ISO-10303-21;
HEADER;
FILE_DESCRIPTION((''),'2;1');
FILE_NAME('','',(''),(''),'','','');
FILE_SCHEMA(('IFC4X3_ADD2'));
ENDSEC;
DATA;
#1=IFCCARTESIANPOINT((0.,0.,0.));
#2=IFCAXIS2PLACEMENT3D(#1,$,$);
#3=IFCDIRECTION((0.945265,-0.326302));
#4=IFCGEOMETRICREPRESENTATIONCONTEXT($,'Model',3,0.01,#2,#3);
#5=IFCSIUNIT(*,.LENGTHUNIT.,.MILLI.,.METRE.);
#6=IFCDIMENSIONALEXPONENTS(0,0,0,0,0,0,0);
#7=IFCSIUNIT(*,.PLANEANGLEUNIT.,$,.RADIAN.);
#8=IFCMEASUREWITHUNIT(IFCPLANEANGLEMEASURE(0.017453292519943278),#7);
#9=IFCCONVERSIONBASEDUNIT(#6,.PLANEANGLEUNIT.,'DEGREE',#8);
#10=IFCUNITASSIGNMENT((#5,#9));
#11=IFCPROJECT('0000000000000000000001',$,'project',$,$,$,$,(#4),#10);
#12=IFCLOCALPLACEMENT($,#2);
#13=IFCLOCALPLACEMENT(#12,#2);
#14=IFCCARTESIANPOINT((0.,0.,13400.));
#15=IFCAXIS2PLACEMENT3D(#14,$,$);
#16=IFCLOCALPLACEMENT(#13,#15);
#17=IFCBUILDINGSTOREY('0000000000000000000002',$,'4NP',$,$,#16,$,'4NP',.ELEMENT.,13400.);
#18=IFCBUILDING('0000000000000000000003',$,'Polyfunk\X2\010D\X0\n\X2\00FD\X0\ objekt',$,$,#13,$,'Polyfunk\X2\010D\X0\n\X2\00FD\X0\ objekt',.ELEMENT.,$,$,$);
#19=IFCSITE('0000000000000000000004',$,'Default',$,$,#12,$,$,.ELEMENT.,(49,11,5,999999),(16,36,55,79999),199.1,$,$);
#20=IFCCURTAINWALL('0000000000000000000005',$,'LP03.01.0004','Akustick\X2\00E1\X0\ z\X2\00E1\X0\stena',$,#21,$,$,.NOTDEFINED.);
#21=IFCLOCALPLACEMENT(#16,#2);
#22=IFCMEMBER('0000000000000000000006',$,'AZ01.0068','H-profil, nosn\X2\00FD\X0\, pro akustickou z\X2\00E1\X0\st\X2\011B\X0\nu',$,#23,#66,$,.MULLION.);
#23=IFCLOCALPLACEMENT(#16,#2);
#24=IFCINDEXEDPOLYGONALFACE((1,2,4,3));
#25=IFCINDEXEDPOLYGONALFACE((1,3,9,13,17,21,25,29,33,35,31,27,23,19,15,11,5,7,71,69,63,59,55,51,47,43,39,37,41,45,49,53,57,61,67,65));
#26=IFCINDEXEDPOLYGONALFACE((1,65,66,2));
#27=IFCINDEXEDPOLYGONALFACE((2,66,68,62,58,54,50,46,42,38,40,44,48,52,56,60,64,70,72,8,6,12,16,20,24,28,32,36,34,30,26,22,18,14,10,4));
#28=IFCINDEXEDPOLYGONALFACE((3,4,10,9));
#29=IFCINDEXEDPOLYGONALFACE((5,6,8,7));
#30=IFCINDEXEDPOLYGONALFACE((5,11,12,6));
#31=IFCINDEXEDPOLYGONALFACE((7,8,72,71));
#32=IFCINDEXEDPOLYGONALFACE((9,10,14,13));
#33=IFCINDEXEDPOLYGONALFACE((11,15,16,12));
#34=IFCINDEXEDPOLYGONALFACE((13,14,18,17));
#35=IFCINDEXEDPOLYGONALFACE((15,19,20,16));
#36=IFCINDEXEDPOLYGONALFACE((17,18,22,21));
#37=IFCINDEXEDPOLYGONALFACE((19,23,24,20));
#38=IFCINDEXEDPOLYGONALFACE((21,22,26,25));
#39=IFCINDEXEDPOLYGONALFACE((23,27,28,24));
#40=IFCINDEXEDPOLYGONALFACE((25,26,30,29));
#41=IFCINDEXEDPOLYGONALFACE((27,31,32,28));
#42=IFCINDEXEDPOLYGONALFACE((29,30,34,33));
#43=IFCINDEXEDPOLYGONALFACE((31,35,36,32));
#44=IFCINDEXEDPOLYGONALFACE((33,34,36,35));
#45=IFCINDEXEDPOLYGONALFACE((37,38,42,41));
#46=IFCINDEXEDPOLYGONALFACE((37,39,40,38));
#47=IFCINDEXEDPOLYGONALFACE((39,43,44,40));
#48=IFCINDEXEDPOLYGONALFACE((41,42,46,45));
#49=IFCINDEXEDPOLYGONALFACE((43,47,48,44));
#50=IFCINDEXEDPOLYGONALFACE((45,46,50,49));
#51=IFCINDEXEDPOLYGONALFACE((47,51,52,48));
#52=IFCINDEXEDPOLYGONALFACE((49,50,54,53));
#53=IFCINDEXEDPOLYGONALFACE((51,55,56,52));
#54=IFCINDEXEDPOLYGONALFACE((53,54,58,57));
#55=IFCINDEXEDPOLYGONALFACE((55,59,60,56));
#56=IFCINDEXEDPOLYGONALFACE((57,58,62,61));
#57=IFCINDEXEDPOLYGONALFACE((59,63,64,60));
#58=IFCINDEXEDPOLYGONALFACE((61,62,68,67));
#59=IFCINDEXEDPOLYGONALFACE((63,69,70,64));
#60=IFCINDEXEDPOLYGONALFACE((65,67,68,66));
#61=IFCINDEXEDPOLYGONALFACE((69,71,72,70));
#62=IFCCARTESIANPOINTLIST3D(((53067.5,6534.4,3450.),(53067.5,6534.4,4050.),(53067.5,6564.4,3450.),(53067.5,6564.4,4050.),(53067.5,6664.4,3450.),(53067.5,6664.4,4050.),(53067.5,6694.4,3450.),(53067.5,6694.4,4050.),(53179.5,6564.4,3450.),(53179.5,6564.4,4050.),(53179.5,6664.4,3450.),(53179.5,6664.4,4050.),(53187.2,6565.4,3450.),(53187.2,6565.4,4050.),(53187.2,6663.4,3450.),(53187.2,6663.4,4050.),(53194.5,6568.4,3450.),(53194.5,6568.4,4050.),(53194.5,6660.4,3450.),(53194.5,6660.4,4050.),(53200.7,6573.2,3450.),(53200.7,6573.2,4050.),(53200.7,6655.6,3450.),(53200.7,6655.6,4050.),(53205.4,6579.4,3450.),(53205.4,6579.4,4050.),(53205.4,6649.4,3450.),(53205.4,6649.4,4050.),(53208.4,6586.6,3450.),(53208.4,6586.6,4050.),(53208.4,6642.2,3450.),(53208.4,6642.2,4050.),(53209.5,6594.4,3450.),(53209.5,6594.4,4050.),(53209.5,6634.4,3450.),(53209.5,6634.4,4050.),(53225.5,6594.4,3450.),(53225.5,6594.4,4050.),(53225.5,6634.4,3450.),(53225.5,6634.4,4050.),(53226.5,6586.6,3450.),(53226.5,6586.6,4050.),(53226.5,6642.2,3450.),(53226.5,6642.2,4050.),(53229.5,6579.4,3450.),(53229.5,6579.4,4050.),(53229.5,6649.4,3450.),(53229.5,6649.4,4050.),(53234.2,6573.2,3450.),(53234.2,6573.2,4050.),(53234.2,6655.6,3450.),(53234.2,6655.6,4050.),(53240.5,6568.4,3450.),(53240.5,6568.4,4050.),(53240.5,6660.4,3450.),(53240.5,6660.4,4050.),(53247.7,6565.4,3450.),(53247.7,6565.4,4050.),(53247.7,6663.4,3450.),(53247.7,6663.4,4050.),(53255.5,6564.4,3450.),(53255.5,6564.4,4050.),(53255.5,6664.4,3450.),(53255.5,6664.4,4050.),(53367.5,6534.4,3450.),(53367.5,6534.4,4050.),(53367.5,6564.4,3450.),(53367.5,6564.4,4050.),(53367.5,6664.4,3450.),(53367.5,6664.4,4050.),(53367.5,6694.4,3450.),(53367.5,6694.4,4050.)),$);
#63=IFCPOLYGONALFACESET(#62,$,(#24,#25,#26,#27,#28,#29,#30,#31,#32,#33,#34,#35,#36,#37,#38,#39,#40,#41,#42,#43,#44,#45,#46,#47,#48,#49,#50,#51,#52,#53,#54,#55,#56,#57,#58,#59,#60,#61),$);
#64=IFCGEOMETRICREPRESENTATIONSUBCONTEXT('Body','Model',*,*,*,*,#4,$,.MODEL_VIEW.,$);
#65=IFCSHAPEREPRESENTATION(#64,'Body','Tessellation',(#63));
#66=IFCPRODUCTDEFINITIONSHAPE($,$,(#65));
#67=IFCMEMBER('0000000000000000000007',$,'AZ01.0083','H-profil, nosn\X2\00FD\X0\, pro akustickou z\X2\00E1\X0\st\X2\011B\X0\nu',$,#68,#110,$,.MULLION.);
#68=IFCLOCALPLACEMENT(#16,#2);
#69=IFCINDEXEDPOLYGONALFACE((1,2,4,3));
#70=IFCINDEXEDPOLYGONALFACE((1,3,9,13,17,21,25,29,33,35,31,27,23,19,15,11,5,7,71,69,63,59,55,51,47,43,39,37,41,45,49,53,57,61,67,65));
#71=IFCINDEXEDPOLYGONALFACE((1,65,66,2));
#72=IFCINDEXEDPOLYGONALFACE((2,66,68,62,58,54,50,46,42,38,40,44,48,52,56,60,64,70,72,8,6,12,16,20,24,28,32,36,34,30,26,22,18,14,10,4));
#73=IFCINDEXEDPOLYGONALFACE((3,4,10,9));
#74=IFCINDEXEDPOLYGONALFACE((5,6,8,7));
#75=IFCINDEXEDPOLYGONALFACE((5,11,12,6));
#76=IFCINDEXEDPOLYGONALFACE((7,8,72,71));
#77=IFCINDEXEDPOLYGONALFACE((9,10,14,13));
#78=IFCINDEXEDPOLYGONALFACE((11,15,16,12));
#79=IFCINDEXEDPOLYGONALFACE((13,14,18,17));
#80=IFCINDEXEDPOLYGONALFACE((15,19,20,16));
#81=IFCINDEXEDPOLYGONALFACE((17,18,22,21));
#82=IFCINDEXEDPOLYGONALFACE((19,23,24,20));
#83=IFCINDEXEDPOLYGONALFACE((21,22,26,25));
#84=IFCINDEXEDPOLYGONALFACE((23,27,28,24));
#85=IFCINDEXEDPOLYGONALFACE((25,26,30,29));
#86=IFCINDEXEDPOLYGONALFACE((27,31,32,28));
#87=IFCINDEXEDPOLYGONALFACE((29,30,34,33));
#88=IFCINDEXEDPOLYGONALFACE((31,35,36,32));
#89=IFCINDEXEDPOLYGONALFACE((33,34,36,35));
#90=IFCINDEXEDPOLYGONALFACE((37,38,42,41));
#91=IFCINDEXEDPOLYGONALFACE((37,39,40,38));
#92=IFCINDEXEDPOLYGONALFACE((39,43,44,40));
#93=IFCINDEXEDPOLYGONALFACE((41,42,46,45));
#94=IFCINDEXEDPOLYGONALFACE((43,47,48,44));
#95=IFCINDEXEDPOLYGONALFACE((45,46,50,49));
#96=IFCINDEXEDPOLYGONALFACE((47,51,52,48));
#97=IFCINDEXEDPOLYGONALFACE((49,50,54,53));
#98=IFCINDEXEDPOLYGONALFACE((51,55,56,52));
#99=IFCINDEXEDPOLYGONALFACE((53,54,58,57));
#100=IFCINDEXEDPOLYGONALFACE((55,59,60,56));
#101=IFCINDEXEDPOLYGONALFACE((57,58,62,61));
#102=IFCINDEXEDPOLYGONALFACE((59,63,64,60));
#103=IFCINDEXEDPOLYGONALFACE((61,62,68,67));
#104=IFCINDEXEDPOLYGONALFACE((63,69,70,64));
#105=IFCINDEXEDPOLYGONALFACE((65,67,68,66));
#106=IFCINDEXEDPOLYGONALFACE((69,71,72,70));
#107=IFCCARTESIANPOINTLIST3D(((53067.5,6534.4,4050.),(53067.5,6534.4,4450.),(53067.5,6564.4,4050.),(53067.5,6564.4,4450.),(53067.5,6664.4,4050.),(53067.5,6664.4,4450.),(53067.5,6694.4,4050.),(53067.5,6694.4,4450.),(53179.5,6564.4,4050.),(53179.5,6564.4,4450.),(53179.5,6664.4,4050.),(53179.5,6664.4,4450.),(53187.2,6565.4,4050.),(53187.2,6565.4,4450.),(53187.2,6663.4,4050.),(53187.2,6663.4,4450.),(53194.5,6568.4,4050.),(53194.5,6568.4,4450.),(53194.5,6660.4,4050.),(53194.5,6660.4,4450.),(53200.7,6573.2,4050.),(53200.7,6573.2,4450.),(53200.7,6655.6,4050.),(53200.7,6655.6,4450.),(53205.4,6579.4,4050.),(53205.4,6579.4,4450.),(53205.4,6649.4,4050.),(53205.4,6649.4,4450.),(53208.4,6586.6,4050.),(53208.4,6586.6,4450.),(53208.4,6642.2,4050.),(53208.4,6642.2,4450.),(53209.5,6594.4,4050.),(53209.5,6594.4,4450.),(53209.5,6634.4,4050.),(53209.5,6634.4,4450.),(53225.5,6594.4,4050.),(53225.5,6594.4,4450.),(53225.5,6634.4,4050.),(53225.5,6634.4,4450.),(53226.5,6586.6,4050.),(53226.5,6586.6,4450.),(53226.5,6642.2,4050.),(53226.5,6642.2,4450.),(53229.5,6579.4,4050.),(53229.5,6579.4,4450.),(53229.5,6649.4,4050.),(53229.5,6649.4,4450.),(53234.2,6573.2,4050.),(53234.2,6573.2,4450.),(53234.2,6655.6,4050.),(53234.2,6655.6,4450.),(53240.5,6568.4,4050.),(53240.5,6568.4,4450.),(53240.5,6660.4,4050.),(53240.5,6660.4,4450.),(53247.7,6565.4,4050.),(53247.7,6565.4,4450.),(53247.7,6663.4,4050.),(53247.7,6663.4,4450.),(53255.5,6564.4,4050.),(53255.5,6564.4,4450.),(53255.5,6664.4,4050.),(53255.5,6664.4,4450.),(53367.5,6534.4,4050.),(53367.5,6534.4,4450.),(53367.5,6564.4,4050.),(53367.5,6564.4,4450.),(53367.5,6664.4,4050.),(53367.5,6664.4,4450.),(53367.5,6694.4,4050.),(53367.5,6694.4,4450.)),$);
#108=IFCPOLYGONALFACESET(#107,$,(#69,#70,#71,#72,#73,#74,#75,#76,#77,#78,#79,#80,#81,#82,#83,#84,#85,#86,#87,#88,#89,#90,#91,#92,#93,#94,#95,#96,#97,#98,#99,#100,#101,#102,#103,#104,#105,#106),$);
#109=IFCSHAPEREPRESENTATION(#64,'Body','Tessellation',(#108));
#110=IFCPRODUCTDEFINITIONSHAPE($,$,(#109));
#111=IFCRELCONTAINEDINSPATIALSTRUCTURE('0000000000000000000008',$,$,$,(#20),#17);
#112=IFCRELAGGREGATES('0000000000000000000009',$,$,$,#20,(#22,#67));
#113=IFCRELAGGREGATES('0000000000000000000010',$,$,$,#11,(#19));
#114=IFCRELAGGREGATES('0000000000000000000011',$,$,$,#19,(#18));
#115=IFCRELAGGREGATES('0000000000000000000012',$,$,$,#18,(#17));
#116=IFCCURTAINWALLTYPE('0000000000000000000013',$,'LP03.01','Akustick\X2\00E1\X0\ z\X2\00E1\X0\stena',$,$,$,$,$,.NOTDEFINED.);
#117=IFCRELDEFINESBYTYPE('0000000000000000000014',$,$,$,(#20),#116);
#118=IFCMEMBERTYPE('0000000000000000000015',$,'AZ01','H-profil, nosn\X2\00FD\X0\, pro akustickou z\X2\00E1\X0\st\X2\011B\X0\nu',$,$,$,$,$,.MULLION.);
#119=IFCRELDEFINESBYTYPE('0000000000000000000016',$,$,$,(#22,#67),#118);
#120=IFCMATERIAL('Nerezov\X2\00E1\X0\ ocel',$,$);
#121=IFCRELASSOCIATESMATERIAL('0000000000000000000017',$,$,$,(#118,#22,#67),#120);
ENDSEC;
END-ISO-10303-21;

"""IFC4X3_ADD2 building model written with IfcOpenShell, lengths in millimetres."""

from ifc_helpers import new_model, entity, si_unit, converted_unit, direction, frame, frame_2d, origin, place, context, subcontext, project, spatial, polyline, circle_curve, parameter, trimmed, segment, composite_curve, outline, extrude, source, transform, mapped, material, material_profile, profile_set, profile_usage, type_object, element, aggregate, save


model = new_model("IFC4X3_ADD2")

# Units and contexts
model_context = context("Model", 3, precision=0.01, world=origin(), true_north=direction((0.945265, -0.326302)))
body_context = subcontext(model_context, "Body", "Model", "MODEL_VIEW")
ifc_project = project(units=[si_unit("LENGTHUNIT", "METRE", prefix="MILLI"), converted_unit("PLANEANGLEUNIT", "DEGREE", entity("IfcPlaneAngleMeasure", 0.017453292519943278), si_unit("PLANEANGLEUNIT", "RADIAN"), dimensions=[0, 0, 0, 0, 0, 0, 0])], contexts=[model_context])

# Site, building, storey
site_placement = place(None, origin())
site = spatial("IfcSite", under=ifc_project, at=site_placement, Name="Default", CompositionType="ELEMENT", RefLatitude=(49, 11, 5, 999999), RefLongitude=(16, 36, 55, 79999), RefElevation=199.1)
building_placement = place(site_placement, origin())
building = spatial("IfcBuilding", under=site, at=building_placement, Name="Polyfunkčný objekt", LongName="Polyfunkčný objekt", CompositionType="ELEMENT")
storey_placement = place(building_placement, frame((0.0, 0.0, 13400.0)))
storey = spatial("IfcBuildingStorey", under=building, at=storey_placement, Name="4NP", LongName="4NP", CompositionType="ELEMENT", Elevation=13400.0)

# Curtain wall, members
curtain_wall_type = type_object("IfcCurtainWallType", Name="LP03.01", Description="Akustická zástena", PredefinedType="NOTDEFINED")
curtain_wall_placement = place(storey_placement, frame((0.0, 0.0, -13400.0)))
curtain_wall = element("IfcCurtainWall", 1, at=curtain_wall_placement, inside=storey, type_object=curtain_wall_type, Name="LP03.01.0004", Description="Akustická zástena", PredefinedType="NOTDEFINED")
ifc_material_1 = material(Name="Nerezová ocel")
ifc_material_profile = material_profile(ifc_material_1, outline(composite_curve([segment(polyline([(50.0, -150.0), (80.0, -150.0)]), True, "CONTINUOUS"), segment(polyline([(80.0, -150.0), (80.0, 150.0)]), True, "CONTINUOUS"), segment(polyline([(80.0, 150.0), (50.0, 150.0)]), True, "CONTINUOUS"), segment(polyline([(50.0, 150.0), (50.0, 38.0)]), True, "CONTINUOUS"), segment(trimmed(circle_curve(frame_2d((20.0, 38.0), x_axis=(0.0, 1.0)), 30.0), [parameter(180.0)], [parameter(270.0)], True, "PARAMETER"), False, "CONTINUOUS"), segment(polyline([(20.0, 8.0), (-20.0, 8.0)]), True, "CONTINUOUS"), segment(trimmed(circle_curve(frame_2d((-20.0, 38.0), x_axis=(0.0, 1.0)), 30.0), [parameter(90.0)], [parameter(180.0)], True, "PARAMETER"), False, "CONTINUOUS"), segment(polyline([(-50.0, 38.0), (-50.0, 150.0)]), True, "CONTINUOUS"), segment(polyline([(-50.0, 150.0), (-80.0, 150.0)]), True, "CONTINUOUS"), segment(polyline([(-80.0, 150.0), (-80.0, -150.0)]), True, "CONTINUOUS"), segment(polyline([(-80.0, -150.0), (-50.0, -150.0)]), True, "CONTINUOUS"), segment(polyline([(-50.0, -150.0), (-50.0, -38.0)]), True, "CONTINUOUS"), segment(trimmed(circle_curve(frame_2d((-20.0, -38.0), x_axis=(0.0, 1.0)), 30.0), [parameter(0.0)], [parameter(90.0)], True, "PARAMETER"), False, "CONTINUOUS"), segment(polyline([(-20.0, -8.0), (20.0, -8.0)]), True, "CONTINUOUS"), segment(trimmed(circle_curve(frame_2d((20.0, -38.0), x_axis=(0.0, 1.0)), 30.0), [parameter(270.0)], [parameter(0.0)], True, "PARAMETER"), False, "CONTINUOUS"), segment(polyline([(50.0, -38.0), (50.0, -150.0)]), True, "CONTINUOUS")], self_intersect=False)), Name="Profil zástena")
ifc_profile_set = profile_set([ifc_material_profile], Name="Profil zástena")
ifc_profile_usage = profile_usage(ifc_profile_set)
member_type = type_object("IfcMemberType", Name="AZ01", Description="H-profil, nosný, pro akustickou zástěnu", PredefinedType="MULLION", material=ifc_profile_set)
shared_shape_1 = source(origin(), body_context, "Body", "SweptSolid", [
    extrude(outline(composite_curve([segment(polyline([(50.0, -150.0), (80.0, -150.0)]), True, "CONTINUOUS"), segment(polyline([(80.0, -150.0), (80.0, 150.0)]), True, "CONTINUOUS"), segment(polyline([(80.0, 150.0), (50.0, 150.0)]), True, "CONTINUOUS"), segment(polyline([(50.0, 150.0), (50.0, 38.0)]), True, "CONTINUOUS"), segment(trimmed(circle_curve(frame_2d((20.0, 38.0), x_axis=(0.0, 1.0)), 30.0), [parameter(180.0)], [parameter(270.0)], True, "PARAMETER"), False, "CONTINUOUS"), segment(polyline([(20.0, 8.0), (-20.0, 8.0)]), True, "CONTINUOUS"), segment(trimmed(circle_curve(frame_2d((-20.0, 38.0), x_axis=(0.0, 1.0)), 30.0), [parameter(90.0)], [parameter(180.0)], True, "PARAMETER"), False, "CONTINUOUS"), segment(polyline([(-50.0, 38.0), (-50.0, 150.0)]), True, "CONTINUOUS"), segment(polyline([(-50.0, 150.0), (-80.0, 150.0)]), True, "CONTINUOUS"), segment(polyline([(-80.0, 150.0), (-80.0, -150.0)]), True, "CONTINUOUS"), segment(polyline([(-80.0, -150.0), (-50.0, -150.0)]), True, "CONTINUOUS"), segment(polyline([(-50.0, -150.0), (-50.0, -38.0)]), True, "CONTINUOUS"), segment(trimmed(circle_curve(frame_2d((-20.0, -38.0), x_axis=(0.0, 1.0)), 30.0), [parameter(0.0)], [parameter(90.0)], True, "PARAMETER"), False, "CONTINUOUS"), segment(polyline([(-20.0, -8.0), (20.0, -8.0)]), True, "CONTINUOUS"), segment(trimmed(circle_curve(frame_2d((20.0, -38.0), x_axis=(0.0, 1.0)), 30.0), [parameter(270.0)], [parameter(0.0)], True, "PARAMETER"), False, "CONTINUOUS"), segment(polyline([(50.0, -38.0), (50.0, -150.0)]), True, "CONTINUOUS")], self_intersect=False)), frame((0.0, 0.0, -600.0), z_axis=(0.0, 0.0, 1.0), x_axis=(0.0, -1.0, 0.0)), (0.0, 0.0, 1.0), 600.0),
])
member_1_placement = place(curtain_wall_placement, frame((53217.5, 6614.4, 16850.0), z_axis=(0.0, 0.0, -1.0), x_axis=(1.0, 0.0, 0.0)))
member_1 = element("IfcMember", 2, at=member_1_placement, type_object=member_type, material=ifc_profile_usage, Name="AZ01.0068", Description="H-profil, nosný, pro akustickou zástěnu", PredefinedType="MULLION", context=body_context, shape_type="MappedRepresentation", body=[
    mapped(shared_shape_1, transform((0.0, 0.0, 0.0), scale=1.0)),
])
shared_shape_2 = source(origin(), body_context, "Body", "SweptSolid", [
    extrude(outline(composite_curve([segment(polyline([(50.0, -150.0), (80.0, -150.0)]), True, "CONTINUOUS"), segment(polyline([(80.0, -150.0), (80.0, 150.0)]), True, "CONTINUOUS"), segment(polyline([(80.0, 150.0), (50.0, 150.0)]), True, "CONTINUOUS"), segment(polyline([(50.0, 150.0), (50.0, 38.0)]), True, "CONTINUOUS"), segment(trimmed(circle_curve(frame_2d((20.0, 38.0), x_axis=(0.0, 1.0)), 30.0), [parameter(180.0)], [parameter(270.0)], True, "PARAMETER"), False, "CONTINUOUS"), segment(polyline([(20.0, 8.0), (-20.0, 8.0)]), True, "CONTINUOUS"), segment(trimmed(circle_curve(frame_2d((-20.0, 38.0), x_axis=(0.0, 1.0)), 30.0), [parameter(90.0)], [parameter(180.0)], True, "PARAMETER"), False, "CONTINUOUS"), segment(polyline([(-50.0, 38.0), (-50.0, 150.0)]), True, "CONTINUOUS"), segment(polyline([(-50.0, 150.0), (-80.0, 150.0)]), True, "CONTINUOUS"), segment(polyline([(-80.0, 150.0), (-80.0, -150.0)]), True, "CONTINUOUS"), segment(polyline([(-80.0, -150.0), (-50.0, -150.0)]), True, "CONTINUOUS"), segment(polyline([(-50.0, -150.0), (-50.0, -38.0)]), True, "CONTINUOUS"), segment(trimmed(circle_curve(frame_2d((-20.0, -38.0), x_axis=(0.0, 1.0)), 30.0), [parameter(0.0)], [parameter(90.0)], True, "PARAMETER"), False, "CONTINUOUS"), segment(polyline([(-20.0, -8.0), (20.0, -8.0)]), True, "CONTINUOUS"), segment(trimmed(circle_curve(frame_2d((20.0, -38.0), x_axis=(0.0, 1.0)), 30.0), [parameter(270.0)], [parameter(0.0)], True, "PARAMETER"), False, "CONTINUOUS"), segment(polyline([(50.0, -38.0), (50.0, -150.0)]), True, "CONTINUOUS")], self_intersect=False)), frame((0.0, 0.0, -400.0), z_axis=(0.0, 0.0, 1.0), x_axis=(0.0, -1.0, 0.0)), (0.0, 0.0, 1.0), 400.0),
])
member_2_placement = place(curtain_wall_placement, frame((53217.5, 6614.4, 17450.0), z_axis=(0.0, 0.0, -1.0), x_axis=(1.0, 0.0, 0.0)))
member_2 = element("IfcMember", 3, at=member_2_placement, type_object=member_type, material=ifc_profile_usage, Name="AZ01.0083", Description="H-profil, nosný, pro akustickou zástěnu", PredefinedType="MULLION", context=body_context, shape_type="MappedRepresentation", body=[
    mapped(shared_shape_2, transform((0.0, 0.0, 0.0), scale=1.0)),
])
aggregate(curtain_wall, [member_1, member_2])

save(model, "model.ifc")
